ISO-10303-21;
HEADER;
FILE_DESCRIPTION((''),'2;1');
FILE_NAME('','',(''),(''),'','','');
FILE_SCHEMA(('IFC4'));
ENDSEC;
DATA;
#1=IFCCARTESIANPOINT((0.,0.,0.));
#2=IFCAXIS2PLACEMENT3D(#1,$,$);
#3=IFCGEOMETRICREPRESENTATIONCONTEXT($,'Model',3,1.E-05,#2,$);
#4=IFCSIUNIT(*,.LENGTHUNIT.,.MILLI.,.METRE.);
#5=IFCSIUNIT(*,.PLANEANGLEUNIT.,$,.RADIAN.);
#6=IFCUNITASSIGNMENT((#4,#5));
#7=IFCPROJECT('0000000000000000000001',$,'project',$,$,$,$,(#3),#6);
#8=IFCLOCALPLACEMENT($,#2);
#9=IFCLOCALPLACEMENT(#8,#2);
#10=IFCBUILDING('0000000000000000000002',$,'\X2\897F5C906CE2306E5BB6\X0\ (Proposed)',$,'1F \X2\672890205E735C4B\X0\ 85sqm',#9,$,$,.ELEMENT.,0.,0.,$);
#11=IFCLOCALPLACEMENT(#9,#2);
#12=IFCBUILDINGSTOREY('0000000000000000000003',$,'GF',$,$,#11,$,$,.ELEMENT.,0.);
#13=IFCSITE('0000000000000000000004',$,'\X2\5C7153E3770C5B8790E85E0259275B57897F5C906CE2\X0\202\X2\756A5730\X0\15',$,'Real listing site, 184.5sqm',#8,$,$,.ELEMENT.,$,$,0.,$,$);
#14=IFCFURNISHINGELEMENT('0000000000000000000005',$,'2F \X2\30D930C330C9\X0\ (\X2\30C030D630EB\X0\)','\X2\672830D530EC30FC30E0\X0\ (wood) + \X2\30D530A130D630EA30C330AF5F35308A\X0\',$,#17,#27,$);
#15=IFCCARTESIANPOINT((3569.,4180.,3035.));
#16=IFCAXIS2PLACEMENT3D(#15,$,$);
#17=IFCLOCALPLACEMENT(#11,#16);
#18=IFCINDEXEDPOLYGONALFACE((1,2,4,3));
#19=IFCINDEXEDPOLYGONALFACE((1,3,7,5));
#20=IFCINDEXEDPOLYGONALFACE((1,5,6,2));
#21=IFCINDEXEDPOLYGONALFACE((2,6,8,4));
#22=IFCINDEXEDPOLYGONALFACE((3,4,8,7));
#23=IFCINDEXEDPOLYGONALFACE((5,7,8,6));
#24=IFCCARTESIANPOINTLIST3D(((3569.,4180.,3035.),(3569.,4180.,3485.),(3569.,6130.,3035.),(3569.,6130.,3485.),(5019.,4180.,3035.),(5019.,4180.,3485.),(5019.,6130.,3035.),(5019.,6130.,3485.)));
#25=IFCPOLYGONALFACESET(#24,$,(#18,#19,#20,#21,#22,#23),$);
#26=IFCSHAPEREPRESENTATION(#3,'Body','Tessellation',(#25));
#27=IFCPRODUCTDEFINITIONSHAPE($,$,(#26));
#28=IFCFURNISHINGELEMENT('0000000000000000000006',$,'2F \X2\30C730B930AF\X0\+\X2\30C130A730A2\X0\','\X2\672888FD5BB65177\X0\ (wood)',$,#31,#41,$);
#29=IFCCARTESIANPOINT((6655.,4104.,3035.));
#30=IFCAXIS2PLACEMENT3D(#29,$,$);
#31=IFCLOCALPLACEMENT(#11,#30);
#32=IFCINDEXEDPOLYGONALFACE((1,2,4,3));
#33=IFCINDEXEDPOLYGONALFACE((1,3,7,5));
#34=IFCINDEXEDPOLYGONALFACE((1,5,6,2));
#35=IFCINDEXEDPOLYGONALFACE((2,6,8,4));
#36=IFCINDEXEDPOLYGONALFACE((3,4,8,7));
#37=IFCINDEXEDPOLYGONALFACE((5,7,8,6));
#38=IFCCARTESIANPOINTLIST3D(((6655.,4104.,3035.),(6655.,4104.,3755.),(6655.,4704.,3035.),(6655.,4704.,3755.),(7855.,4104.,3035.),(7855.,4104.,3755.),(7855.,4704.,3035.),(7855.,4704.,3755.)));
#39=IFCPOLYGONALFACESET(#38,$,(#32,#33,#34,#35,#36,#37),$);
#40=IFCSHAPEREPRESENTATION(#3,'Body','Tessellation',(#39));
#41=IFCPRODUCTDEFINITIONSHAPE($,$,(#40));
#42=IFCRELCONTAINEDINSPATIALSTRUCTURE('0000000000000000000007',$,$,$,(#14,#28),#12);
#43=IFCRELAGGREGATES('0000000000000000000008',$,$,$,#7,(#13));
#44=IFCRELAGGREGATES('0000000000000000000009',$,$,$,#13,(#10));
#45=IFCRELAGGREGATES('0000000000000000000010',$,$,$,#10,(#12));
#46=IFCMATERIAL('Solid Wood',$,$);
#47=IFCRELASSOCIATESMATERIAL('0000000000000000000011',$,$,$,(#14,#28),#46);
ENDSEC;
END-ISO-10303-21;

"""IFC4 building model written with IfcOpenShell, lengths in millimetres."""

from ifc_helpers import new_model, si_unit, frame, frame_2d, origin, place, context, project, spatial, rectangle, extrude, material, element, save


model = new_model("IFC4")

# Units and contexts
model_context = context("Model", 3, precision=1e-05, world=origin())
ifc_project = project(units=[si_unit("LENGTHUNIT", "METRE", prefix="MILLI"), si_unit("PLANEANGLEUNIT", "RADIAN")], contexts=[model_context])

# Site, building, storey
site_placement = place(None, origin())
site = spatial("IfcSite", under=ifc_project, at=site_placement, Name="山口県宇部市大字西岐波202番地15", ObjectType="Real listing site, 184.5sqm", CompositionType="ELEMENT", RefElevation=0.0)
building_placement = place(site_placement, origin())
building = spatial("IfcBuilding", under=site, at=building_placement, Name="西岐波の家 (Proposed)", ObjectType="1F 木造平屋 85sqm", CompositionType="ELEMENT", ElevationOfRefHeight=0.0, ElevationOfTerrain=0.0)
storey_placement = place(building_placement, origin())
storey = spatial("IfcBuildingStorey", under=building, at=storey_placement, Name="GF", CompositionType="ELEMENT", Elevation=0.0)

# Shared definitions
ifc_material_1 = material(Name="Solid Wood")

# Furnishing elements
furnishing_1_placement = place(storey_placement, frame((3569.0, 4180.0, 3035.0)))
element("IfcFurnishingElement", 1, at=furnishing_1_placement, inside=storey, material=ifc_material_1, Name="2F ベッド (ダブル)", Description="木フレーム (wood) + ファブリック張り", context=model_context, shape_type="SweptSolid", body=[
    extrude(rectangle(XDim=1450.0, YDim=1950.0, at=frame_2d((725.0, 975.0))), frame((3569.0, 4180.0, 3035.0)), (0.0, 0.0, 1.0), 450.0),
])
furnishing_2_placement = place(storey_placement, frame((6655.0, 4104.0, 3035.0)))
element("IfcFurnishingElement", 2, at=furnishing_2_placement, inside=storey, material=ifc_material_1, Name="2F デスク+チェア", Description="木製家具 (wood)", context=model_context, shape_type="SweptSolid", body=[
    extrude(rectangle(XDim=1200.0, YDim=600.0, at=frame_2d((600.0, 300.0))), frame((6655.0, 4104.0, 3035.0)), (0.0, 0.0, 1.0), 720.0),
])

save(model, "model.ifc")
